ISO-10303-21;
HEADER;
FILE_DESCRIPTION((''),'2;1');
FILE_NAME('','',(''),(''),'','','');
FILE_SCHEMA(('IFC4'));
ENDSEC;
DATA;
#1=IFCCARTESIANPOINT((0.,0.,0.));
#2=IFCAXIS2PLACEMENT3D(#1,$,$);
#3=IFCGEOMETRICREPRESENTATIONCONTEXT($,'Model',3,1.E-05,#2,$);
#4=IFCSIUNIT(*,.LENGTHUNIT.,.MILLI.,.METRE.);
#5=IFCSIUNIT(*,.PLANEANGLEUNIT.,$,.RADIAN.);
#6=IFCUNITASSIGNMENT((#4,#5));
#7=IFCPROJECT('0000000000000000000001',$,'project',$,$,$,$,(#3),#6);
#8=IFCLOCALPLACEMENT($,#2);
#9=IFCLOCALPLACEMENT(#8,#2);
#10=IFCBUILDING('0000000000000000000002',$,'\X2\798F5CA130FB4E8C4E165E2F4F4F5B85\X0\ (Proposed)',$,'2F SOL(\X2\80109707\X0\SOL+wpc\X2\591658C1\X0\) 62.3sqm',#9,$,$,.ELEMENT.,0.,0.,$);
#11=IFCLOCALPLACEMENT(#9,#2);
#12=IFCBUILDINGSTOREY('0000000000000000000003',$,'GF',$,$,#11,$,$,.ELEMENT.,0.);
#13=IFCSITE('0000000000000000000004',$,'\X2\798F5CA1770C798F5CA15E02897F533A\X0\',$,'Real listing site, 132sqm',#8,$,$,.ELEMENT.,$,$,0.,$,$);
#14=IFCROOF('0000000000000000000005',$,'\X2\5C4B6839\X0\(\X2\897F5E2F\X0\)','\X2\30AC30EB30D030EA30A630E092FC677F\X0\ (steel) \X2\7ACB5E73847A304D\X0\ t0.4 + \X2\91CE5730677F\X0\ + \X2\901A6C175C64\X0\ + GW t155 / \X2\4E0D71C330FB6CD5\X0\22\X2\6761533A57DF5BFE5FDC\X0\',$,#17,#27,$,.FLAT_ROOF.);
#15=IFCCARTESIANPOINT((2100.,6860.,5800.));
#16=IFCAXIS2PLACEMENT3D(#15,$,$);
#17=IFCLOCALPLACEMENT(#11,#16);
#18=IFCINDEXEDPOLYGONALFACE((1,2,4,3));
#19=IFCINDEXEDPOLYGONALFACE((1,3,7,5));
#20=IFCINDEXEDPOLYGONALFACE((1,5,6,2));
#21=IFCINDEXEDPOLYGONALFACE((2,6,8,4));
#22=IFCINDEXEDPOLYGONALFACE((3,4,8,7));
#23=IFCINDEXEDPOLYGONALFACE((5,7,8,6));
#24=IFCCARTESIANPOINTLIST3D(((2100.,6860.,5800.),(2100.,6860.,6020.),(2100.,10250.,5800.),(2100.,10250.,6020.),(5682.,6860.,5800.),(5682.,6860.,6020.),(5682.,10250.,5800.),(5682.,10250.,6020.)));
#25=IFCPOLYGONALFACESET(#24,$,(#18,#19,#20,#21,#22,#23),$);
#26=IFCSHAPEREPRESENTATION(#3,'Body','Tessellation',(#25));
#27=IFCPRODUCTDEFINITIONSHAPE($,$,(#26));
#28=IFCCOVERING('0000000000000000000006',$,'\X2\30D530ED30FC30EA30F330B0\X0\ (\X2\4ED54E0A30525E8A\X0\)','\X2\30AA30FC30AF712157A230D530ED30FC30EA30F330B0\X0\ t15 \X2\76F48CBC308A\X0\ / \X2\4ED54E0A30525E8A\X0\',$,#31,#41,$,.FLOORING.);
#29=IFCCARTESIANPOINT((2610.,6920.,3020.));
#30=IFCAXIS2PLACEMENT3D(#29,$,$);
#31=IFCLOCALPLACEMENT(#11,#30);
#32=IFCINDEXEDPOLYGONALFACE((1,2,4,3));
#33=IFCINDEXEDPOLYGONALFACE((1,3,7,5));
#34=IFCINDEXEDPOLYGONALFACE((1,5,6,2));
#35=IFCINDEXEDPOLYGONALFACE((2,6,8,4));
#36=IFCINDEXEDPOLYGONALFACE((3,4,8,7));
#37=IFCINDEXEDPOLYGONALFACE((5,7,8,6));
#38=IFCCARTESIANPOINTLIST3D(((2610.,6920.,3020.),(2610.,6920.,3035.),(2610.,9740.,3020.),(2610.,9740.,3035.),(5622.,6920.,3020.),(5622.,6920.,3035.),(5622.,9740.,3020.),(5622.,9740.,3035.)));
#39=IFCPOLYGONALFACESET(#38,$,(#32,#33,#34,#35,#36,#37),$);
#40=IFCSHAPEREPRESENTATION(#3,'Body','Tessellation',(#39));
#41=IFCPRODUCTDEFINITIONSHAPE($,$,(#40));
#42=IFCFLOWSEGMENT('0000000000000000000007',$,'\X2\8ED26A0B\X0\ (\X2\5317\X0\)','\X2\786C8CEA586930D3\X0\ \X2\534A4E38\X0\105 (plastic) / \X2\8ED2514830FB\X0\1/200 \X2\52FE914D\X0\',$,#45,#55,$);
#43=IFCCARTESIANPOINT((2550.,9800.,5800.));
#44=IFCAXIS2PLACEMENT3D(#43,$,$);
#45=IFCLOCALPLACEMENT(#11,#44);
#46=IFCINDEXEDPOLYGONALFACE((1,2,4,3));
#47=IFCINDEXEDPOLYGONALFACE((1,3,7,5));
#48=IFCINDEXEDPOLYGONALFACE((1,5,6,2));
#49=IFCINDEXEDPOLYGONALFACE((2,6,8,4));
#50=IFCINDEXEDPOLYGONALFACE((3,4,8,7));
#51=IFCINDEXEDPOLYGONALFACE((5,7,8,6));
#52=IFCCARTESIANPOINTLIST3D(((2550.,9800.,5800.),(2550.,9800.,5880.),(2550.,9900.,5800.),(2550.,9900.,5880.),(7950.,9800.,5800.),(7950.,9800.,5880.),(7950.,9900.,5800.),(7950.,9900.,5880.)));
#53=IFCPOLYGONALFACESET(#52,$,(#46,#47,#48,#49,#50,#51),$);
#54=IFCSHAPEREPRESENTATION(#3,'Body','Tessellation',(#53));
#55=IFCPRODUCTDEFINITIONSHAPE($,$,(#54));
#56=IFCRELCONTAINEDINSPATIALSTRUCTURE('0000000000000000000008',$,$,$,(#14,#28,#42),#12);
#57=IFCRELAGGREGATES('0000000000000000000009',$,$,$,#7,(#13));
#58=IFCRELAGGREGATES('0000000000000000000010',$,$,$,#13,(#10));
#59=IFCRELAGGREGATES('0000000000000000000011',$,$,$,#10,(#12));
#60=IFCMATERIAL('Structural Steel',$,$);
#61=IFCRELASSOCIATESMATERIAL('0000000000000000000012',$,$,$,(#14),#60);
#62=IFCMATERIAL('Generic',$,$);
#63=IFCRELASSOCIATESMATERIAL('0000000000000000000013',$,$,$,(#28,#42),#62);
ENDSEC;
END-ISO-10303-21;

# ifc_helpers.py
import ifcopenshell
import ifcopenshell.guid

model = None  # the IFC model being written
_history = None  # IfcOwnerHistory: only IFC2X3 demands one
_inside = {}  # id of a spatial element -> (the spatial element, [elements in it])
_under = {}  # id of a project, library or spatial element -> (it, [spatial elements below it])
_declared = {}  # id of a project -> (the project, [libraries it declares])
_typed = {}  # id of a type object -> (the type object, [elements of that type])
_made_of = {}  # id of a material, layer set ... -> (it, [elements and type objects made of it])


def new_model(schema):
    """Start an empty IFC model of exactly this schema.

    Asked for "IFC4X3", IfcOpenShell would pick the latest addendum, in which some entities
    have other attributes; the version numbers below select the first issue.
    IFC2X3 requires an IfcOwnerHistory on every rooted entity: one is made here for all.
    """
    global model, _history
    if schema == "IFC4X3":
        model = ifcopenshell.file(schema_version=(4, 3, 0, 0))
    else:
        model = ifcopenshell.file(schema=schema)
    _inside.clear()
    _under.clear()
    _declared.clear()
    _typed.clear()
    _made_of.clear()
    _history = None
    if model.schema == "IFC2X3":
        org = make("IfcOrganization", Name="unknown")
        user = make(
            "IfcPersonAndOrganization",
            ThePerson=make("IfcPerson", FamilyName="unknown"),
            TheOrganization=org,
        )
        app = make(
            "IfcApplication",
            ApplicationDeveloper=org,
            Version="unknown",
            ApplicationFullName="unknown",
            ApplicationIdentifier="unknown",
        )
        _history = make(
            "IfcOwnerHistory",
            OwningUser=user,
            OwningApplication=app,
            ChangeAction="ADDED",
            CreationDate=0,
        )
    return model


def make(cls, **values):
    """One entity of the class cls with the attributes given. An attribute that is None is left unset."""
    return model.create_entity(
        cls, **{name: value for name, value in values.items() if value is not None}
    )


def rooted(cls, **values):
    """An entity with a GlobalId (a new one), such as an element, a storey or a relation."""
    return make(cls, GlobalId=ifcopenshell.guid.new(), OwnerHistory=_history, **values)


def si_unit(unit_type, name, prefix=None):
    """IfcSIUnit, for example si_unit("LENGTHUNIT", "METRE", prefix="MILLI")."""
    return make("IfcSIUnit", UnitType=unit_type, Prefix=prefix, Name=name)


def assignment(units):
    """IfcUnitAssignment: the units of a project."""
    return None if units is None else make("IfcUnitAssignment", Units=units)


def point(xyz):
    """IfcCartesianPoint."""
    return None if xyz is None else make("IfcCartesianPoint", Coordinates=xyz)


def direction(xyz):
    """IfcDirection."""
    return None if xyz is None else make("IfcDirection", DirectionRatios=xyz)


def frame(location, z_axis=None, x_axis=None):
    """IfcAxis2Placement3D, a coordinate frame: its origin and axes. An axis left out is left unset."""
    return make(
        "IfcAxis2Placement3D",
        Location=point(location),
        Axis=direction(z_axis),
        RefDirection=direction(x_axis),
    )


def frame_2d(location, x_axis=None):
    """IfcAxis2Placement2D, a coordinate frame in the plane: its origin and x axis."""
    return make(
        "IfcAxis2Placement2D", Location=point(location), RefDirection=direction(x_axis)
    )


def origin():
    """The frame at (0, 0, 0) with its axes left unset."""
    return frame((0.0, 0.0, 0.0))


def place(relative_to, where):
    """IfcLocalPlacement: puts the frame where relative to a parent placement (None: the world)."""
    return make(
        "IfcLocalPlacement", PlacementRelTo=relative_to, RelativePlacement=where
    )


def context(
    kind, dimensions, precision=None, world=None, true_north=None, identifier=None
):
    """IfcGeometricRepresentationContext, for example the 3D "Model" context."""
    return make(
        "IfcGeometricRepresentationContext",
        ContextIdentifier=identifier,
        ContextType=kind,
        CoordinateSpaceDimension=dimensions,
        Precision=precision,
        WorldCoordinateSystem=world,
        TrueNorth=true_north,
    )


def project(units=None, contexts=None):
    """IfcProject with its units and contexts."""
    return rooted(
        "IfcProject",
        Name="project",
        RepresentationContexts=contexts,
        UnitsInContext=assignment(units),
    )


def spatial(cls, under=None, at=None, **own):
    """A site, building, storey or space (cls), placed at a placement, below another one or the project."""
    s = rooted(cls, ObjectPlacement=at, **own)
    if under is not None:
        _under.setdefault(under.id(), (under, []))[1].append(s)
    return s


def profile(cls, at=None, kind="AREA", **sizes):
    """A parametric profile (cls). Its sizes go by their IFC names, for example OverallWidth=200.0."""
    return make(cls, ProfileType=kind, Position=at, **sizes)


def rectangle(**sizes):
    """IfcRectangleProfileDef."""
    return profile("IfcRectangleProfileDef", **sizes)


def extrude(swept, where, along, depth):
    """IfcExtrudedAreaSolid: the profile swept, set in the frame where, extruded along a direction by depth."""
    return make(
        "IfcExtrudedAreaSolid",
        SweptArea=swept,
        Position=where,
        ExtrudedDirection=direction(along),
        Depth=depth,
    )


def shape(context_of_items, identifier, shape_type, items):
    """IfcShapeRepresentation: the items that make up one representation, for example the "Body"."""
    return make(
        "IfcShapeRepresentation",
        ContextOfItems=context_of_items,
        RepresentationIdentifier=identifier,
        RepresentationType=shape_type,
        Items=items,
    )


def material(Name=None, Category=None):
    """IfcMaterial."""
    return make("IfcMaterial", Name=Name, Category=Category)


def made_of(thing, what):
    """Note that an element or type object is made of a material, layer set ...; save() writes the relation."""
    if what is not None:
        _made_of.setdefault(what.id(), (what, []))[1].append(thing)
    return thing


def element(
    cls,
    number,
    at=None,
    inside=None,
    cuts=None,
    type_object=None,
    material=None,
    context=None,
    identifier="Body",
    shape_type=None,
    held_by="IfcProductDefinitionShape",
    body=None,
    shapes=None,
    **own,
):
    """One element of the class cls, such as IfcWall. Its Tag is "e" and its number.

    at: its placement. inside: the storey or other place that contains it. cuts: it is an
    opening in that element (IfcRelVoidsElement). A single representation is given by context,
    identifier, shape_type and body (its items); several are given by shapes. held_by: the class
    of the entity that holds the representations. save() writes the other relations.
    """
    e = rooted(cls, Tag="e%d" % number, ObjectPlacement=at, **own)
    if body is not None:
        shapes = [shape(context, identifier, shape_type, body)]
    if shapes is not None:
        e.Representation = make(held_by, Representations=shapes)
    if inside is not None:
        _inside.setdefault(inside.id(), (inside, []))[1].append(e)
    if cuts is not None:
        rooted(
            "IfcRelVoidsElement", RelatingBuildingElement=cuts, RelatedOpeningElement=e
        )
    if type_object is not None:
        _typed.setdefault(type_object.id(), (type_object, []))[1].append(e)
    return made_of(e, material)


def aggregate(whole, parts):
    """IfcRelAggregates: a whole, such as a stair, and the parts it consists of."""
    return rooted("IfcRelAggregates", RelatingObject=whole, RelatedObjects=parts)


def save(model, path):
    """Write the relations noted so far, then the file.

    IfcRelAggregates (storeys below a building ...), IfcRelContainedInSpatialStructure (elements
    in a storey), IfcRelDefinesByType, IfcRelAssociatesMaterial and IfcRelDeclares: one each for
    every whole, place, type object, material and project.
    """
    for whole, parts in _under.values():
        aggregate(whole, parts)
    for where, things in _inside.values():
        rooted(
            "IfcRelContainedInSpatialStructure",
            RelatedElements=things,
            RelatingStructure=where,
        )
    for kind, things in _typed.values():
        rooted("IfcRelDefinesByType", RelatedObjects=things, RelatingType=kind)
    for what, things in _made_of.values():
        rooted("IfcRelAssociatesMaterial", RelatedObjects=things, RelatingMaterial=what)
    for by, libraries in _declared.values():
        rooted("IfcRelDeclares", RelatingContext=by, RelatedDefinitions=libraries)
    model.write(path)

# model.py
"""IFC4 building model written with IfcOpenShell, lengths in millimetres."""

from ifc_helpers import new_model, si_unit, frame, frame_2d, origin, place, context, project, spatial, rectangle, extrude, material, element, save


model = new_model("IFC4")

# Units and contexts
model_context = context("Model", 3, precision=1e-05, world=origin())
ifc_project = project(units=[si_unit("LENGTHUNIT", "METRE", prefix="MILLI"), si_unit("PLANEANGLEUNIT", "RADIAN")], contexts=[model_context])

# Site, building, storey
site_placement = place(None, origin())
site = spatial("IfcSite", under=ifc_project, at=site_placement, Name="福岡県福岡市西区", ObjectType="Real listing site, 132sqm", CompositionType="ELEMENT", RefElevation=0.0)
building_placement = place(site_placement, origin())
building = spatial("IfcBuilding", under=site, at=building_placement, Name="福岡・二世帯住宅 (Proposed)", ObjectType="2F SOL(耐震SOL+wpc外壁) 62.3sqm", CompositionType="ELEMENT", ElevationOfRefHeight=0.0, ElevationOfTerrain=0.0)
storey_placement = place(building_placement, origin())
storey = spatial("IfcBuildingStorey", under=building, at=storey_placement, Name="GF", CompositionType="ELEMENT", Elevation=0.0)

# Roof
ifc_material_1 = material(Name="Structural Steel")
for number, where, name in (
    (1, (2100.0, 6860.0, 5800.0), "屋根(西帯)"),
):
    element("IfcRoof", number, at=place(storey_placement, frame(where)), inside=storey, material=ifc_material_1, Name=name, Description="ガルバリウム鋼板 (steel) 立平葺き t0.4 + 野地板 + 通気層 + GW t155 / 不燃・法22条区域対応", PredefinedType="FLAT_ROOF", context=model_context, shape_type="SweptSolid", body=[
        extrude(rectangle(XDim=3582.0, YDim=3390.0, at=frame_2d((1791.0, 1695.0))), frame((2100.0, 6860.0, 5800.0)), (0.0, 0.0, 1.0), 220.0),
    ])

# Covering
ifc_material_2 = material(Name="Generic")
covering_placement = place(storey_placement, frame((2610.0, 6920.0, 3020.0)))
element("IfcCovering", 2, at=covering_placement, inside=storey, material=ifc_material_2, Name="フローリング (仕上げ床)", Description="オーク無垢フローリング t15 直貼り / 仕上げ床", PredefinedType="FLOORING", context=model_context, shape_type="SweptSolid", body=[
    extrude(rectangle(XDim=3012.0, YDim=2820.0, at=frame_2d((1506.0, 1410.0))), frame((2610.0, 6920.0, 3020.0)), (0.0, 0.0, 1.0), 15.0),
])

# Flow segment
flow_segment_placement = place(storey_placement, frame((2550.0, 9800.0, 5800.0)))
element("IfcFlowSegment", 3, at=flow_segment_placement, inside=storey, material=ifc_material_2, Name="軒樋 (北)", Description="硬質塩ビ 半丸105 (plastic) / 軒先・1/200 勾配", context=model_context, shape_type="SweptSolid", body=[
    extrude(rectangle(XDim=5400.0, YDim=100.0, at=frame_2d((2700.0, 50.0))), frame((2550.0, 9800.0, 5800.0)), (0.0, 0.0, 1.0), 80.0),
])

save(model, "model.ifc")
